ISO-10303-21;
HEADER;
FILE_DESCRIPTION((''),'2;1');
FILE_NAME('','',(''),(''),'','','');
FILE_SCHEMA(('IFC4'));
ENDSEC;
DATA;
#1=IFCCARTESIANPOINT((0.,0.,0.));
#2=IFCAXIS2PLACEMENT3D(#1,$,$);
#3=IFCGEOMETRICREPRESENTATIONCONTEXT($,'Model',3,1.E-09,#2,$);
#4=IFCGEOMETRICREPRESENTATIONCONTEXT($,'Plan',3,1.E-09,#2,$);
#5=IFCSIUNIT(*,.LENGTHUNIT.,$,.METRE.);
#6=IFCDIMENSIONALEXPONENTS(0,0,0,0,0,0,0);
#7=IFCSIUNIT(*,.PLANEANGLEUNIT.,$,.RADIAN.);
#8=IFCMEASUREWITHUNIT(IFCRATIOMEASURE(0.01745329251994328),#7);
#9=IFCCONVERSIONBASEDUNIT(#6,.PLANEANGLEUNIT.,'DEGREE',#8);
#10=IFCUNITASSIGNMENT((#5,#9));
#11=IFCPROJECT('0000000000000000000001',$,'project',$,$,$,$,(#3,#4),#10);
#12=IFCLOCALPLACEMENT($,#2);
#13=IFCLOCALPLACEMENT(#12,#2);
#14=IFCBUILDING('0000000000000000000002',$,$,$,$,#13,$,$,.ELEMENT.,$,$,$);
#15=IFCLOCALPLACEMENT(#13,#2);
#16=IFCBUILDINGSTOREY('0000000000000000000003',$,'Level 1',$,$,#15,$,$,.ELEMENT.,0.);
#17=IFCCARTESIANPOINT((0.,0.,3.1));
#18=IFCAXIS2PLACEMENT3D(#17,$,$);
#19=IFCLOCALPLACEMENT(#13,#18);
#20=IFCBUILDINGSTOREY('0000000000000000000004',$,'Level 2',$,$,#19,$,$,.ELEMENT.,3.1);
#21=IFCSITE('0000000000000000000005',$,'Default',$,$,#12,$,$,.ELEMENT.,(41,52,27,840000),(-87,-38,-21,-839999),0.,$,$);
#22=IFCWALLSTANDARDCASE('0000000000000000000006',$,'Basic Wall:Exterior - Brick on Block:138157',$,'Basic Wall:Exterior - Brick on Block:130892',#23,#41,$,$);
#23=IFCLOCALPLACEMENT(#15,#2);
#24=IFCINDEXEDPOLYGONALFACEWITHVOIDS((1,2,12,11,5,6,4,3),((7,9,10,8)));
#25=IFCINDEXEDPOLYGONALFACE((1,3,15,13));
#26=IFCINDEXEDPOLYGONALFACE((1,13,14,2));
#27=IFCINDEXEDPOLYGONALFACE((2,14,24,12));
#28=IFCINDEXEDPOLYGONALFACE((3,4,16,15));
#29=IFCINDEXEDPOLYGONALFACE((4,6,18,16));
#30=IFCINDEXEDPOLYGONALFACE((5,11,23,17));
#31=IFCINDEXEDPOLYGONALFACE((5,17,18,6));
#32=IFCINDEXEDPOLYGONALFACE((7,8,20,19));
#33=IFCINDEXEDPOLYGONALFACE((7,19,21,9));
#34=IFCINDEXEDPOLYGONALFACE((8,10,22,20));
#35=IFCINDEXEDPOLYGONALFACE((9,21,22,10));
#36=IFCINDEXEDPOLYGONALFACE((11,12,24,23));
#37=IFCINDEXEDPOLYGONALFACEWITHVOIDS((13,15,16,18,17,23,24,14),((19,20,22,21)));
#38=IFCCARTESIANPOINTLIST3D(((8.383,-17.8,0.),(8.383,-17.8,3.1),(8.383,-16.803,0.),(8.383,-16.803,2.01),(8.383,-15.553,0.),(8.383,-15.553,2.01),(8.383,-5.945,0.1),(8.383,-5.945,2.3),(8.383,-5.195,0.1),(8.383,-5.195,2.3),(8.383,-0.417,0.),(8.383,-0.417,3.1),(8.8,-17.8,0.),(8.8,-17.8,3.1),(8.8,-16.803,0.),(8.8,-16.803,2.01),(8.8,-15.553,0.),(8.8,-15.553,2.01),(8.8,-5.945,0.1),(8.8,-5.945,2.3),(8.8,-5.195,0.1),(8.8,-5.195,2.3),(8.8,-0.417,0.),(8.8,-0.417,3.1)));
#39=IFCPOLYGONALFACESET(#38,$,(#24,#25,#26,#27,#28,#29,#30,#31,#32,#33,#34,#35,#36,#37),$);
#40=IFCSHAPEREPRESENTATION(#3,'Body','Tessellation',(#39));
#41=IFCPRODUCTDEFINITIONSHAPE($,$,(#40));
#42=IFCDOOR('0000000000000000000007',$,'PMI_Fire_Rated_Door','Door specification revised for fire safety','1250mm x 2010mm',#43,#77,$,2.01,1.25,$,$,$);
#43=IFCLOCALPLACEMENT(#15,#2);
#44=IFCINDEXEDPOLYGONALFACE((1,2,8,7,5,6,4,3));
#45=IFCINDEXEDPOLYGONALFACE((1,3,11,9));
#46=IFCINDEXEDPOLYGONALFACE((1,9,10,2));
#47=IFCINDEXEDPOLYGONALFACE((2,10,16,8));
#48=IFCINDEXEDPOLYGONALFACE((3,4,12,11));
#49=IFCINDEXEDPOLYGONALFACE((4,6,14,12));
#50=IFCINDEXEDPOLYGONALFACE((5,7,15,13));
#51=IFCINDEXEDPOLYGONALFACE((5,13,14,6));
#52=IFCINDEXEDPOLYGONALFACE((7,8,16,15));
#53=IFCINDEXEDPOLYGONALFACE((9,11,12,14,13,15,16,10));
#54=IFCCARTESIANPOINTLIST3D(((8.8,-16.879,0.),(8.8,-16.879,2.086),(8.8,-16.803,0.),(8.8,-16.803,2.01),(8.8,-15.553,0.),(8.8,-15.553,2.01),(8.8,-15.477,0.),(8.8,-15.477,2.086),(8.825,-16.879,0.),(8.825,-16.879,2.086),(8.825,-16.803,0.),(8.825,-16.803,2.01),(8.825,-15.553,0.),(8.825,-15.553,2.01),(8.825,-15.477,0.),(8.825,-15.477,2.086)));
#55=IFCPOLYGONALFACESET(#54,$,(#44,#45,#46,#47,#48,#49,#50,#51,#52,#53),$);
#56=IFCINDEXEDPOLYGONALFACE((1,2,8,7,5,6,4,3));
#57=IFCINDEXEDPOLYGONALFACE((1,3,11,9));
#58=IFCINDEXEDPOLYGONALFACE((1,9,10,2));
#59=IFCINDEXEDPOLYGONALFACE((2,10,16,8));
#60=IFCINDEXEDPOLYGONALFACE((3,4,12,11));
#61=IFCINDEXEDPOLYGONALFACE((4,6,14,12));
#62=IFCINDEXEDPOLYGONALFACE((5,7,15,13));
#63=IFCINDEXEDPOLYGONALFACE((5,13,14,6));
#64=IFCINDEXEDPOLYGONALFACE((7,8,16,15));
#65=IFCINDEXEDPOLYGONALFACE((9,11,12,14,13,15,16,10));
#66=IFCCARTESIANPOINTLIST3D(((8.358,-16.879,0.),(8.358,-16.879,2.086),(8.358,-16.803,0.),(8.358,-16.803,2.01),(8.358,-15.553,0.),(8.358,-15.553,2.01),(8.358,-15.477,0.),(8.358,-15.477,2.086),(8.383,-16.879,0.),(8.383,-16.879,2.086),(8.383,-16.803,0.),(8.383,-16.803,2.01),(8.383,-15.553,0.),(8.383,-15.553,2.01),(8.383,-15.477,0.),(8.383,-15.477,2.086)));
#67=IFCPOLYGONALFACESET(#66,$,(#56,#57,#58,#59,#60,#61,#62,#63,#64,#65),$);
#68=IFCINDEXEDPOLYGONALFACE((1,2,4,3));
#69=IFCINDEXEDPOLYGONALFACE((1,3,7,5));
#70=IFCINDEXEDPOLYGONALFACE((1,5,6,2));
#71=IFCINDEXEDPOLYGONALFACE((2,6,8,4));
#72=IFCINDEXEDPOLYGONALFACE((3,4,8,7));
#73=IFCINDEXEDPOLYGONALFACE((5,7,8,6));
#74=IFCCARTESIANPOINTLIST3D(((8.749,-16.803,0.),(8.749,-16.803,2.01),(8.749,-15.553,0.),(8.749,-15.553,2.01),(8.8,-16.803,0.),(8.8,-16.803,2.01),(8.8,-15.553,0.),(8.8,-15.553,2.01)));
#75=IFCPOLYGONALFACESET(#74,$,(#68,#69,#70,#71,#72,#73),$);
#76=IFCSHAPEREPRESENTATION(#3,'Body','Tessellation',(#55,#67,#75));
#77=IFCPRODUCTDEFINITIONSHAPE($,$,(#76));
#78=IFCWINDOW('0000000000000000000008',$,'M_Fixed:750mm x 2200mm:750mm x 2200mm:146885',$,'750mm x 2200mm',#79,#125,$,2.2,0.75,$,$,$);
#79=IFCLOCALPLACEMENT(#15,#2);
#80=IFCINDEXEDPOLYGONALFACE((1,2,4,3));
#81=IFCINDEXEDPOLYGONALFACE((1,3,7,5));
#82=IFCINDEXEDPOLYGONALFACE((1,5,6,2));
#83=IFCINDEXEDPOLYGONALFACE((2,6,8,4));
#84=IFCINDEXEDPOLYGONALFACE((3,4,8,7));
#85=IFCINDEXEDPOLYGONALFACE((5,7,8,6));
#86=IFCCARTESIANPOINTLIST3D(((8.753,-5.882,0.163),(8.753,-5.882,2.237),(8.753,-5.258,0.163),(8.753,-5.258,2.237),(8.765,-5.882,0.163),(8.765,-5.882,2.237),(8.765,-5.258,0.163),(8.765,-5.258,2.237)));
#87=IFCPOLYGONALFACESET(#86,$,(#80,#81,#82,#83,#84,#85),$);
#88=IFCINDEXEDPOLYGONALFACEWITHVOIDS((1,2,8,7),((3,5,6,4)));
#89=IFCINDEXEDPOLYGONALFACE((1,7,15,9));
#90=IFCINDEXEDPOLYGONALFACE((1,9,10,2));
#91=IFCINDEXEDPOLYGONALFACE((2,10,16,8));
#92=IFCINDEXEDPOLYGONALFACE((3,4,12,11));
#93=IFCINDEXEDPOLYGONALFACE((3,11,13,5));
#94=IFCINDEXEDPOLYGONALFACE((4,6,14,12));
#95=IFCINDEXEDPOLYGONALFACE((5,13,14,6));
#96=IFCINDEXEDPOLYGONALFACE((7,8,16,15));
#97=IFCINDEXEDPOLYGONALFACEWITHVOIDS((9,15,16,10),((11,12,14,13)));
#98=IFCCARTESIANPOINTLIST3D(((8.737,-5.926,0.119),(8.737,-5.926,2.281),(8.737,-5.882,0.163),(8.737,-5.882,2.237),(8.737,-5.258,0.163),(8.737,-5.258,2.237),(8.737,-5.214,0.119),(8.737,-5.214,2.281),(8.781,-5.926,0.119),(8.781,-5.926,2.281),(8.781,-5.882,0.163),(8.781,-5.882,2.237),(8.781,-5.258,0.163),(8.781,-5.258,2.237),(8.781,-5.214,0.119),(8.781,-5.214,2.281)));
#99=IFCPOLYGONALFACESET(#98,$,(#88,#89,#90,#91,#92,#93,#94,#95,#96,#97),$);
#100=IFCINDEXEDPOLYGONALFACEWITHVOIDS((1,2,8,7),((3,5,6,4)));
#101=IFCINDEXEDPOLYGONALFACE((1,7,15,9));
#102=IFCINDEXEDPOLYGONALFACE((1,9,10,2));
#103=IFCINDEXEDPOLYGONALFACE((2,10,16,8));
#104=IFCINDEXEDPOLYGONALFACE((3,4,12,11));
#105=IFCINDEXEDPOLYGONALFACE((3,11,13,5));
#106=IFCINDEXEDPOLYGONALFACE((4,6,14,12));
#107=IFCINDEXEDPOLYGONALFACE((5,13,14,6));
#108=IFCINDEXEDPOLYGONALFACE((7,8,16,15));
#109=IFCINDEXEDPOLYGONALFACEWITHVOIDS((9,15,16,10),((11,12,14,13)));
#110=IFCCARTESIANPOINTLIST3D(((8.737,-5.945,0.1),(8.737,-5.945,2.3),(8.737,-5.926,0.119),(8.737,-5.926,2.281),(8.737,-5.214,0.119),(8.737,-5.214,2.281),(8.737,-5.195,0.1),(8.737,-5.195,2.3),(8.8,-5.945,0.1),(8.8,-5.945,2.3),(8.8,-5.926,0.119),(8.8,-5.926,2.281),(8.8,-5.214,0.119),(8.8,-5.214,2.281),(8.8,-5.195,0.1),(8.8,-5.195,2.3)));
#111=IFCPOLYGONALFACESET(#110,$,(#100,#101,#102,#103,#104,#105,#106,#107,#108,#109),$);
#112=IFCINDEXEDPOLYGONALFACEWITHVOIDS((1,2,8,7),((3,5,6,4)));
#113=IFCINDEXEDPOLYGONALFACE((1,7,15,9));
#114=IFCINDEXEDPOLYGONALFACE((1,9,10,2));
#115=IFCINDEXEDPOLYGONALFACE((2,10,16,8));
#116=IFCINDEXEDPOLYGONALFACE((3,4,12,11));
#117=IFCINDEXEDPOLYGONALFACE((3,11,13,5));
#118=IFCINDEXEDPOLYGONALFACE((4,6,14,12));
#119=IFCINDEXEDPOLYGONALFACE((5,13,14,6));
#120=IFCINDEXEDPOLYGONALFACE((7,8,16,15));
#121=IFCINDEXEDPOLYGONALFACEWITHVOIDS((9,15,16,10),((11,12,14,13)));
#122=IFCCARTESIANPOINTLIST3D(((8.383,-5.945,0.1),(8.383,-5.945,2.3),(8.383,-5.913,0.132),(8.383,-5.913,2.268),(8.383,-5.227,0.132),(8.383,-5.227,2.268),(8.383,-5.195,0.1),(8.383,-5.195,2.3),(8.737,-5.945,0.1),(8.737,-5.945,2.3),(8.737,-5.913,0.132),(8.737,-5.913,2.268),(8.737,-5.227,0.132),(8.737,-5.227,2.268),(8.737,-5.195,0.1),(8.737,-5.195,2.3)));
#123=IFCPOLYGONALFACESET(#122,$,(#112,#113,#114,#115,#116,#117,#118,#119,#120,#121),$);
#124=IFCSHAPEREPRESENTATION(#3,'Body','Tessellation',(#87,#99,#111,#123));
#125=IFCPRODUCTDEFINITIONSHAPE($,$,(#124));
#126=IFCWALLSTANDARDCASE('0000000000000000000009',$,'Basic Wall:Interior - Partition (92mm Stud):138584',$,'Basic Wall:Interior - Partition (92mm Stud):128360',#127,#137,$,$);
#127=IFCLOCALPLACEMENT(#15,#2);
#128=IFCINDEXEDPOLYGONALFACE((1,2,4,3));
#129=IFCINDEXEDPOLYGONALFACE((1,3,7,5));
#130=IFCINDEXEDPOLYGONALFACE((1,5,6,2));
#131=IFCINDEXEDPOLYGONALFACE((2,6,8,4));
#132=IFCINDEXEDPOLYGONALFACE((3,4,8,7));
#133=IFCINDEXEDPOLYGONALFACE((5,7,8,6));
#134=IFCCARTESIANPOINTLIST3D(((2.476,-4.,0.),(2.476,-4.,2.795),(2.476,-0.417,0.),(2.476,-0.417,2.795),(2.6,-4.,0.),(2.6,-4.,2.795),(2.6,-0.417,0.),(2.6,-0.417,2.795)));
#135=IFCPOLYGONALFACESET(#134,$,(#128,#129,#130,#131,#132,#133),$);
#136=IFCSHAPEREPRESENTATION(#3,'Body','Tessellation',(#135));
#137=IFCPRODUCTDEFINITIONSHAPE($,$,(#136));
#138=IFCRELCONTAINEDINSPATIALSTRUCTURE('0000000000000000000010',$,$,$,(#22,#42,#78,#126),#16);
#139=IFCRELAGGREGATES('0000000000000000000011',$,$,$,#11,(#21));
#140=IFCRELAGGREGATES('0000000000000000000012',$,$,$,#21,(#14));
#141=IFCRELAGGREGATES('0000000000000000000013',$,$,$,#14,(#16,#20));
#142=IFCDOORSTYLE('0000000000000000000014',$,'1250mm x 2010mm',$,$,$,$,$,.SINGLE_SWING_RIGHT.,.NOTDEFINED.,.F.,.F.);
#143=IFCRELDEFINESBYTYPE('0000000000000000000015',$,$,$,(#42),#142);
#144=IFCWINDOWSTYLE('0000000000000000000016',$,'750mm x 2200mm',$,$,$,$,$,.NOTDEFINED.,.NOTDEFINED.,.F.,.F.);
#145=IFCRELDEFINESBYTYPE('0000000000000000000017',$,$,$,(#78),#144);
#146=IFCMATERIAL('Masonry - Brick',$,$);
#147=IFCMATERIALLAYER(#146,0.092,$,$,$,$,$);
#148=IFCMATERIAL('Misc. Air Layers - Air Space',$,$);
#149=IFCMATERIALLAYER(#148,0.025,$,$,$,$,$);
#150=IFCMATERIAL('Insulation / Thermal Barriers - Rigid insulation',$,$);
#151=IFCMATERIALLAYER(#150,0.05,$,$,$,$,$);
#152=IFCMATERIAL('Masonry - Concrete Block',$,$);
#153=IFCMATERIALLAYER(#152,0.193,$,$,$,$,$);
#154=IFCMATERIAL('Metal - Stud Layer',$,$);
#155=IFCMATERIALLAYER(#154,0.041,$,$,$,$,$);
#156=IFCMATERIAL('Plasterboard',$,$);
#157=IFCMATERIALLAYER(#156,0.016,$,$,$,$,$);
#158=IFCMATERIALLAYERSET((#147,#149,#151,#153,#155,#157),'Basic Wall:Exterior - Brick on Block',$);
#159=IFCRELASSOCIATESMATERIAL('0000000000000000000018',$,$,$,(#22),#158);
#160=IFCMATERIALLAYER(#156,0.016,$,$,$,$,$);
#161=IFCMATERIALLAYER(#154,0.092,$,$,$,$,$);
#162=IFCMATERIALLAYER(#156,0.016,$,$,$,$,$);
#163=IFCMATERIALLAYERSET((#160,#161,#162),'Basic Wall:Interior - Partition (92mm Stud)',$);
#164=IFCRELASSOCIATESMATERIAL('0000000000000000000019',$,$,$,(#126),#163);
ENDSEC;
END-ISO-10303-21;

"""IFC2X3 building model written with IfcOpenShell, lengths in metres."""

from ifc_helpers import new_model, entity, si_unit, converted_unit, frame, frame_2d, origin, origin_2d_with_axis, place, context, project, spatial, polyline, rectangle, outline, extrude, source, transform, mapped, material, layer, layer_set, layer_usage, type_object, type_shapes, element, fill, save


model = new_model("IFC2X3")

# Units and contexts
model_context = context("Model", 3, precision=1e-09, world=origin())
plan_context = context("Plan", 3, precision=1e-09, world=origin())
ifc_project = project(units=[si_unit("LENGTHUNIT", "METRE"), converted_unit("PLANEANGLEUNIT", "DEGREE", entity("IfcRatioMeasure", 0.01745329251994328), si_unit("PLANEANGLEUNIT", "RADIAN"), dimensions=[0, 0, 0, 0, 0, 0, 0])], contexts=[model_context, plan_context])

# Site, building, storey
site_placement = place(None, origin())
site = spatial("IfcSite", under=ifc_project, at=site_placement, Name="Default", CompositionType="ELEMENT", RefLatitude=(41, 52, 27, 840000), RefLongitude=(-87, -38, -21, -839999), RefElevation=0.0)
building_placement = place(site_placement, origin())
building = spatial("IfcBuilding", under=site, at=building_placement, CompositionType="ELEMENT")
storey_1_placement = place(building_placement, origin())
storey_1 = spatial("IfcBuildingStorey", under=building, at=storey_1_placement, Name="Level 1", CompositionType="ELEMENT", Elevation=0.0)

# Shared definitions
ifc_material_1 = material(Name="Masonry - Brick")
ifc_layer_1 = layer(ifc_material_1, 0.092)
ifc_material_2 = material(Name="Misc. Air Layers - Air Space")
ifc_layer_2 = layer(ifc_material_2, 0.025)
ifc_material_3 = material(Name="Insulation / Thermal Barriers - Rigid insulation")
ifc_layer_3 = layer(ifc_material_3, 0.05)
ifc_material_4 = material(Name="Masonry - Concrete Block")
ifc_layer_4 = layer(ifc_material_4, 0.193)
ifc_material_5 = material(Name="Metal - Stud Layer")
ifc_layer_5 = layer(ifc_material_5, 0.041)
ifc_material_6 = material(Name="Plasterboard")
ifc_layer_6 = layer(ifc_material_6, 0.016)
ifc_layer_set_1 = layer_set([ifc_layer_1, ifc_layer_2, ifc_layer_3, ifc_layer_4, ifc_layer_5, ifc_layer_6], Name="Basic Wall:Exterior - Brick on Block")

# Wall, openings, door, window
ifc_layer_usage_1 = layer_usage(ifc_layer_set_1, "AXIS2", "NEGATIVE", 0.2085)
wall_1_placement = place(storey_1_placement, frame((8.5915, -0.417, 0.0), z_axis=(0.0, 0.0, 1.0), x_axis=(0.0, -1.0, 0.0)))
wall_1 = element("IfcWallStandardCase", 1, at=wall_1_placement, inside=storey_1, material=ifc_layer_usage_1, Name="Basic Wall:Exterior - Brick on Block:138157", ObjectType="Basic Wall:Exterior - Brick on Block:130892", context=model_context, shape_type="SweptSolid", body=[
    extrude(rectangle(XDim=17.383, YDim=0.417, at=frame_2d((8.6915, 0.0), x_axis=(-1.0, 0.0))), origin(), (0.0, 0.0, 1.0), 3.1),
])
opening_1_placement = place(wall_1_placement, frame((15.136, -0.2085, 0.0)))
opening_1 = element("IfcOpeningElement", 2, at=opening_1_placement, cuts=wall_1, ObjectType="Opening", context=model_context, shape_type="SweptSolid", body=[
    extrude(rectangle(XDim=1.25, YDim=2.01, at=frame_2d((1.005, 0.625), x_axis=(0.0, 1.0))), frame((0.0, 0.0, 0.0), z_axis=(0.0, 1.0, 0.0), x_axis=(0.0, 0.0, 1.0)), (0.0, 0.0, 1.0), 0.417),
])
opening_2_placement = place(wall_1_placement, frame((4.778, -0.2085, 0.1)))
opening_2 = element("IfcOpeningElement", 3, at=opening_2_placement, cuts=wall_1, ObjectType="Opening", context=model_context, shape_type="SweptSolid", body=[
    extrude(rectangle(XDim=2.2, YDim=0.75, at=frame_2d((1.1, 0.375), x_axis=(1.0, 0.0))), frame((0.0, 0.0, 0.0), z_axis=(0.0, 1.0, 0.0), x_axis=(0.0, 0.0, 1.0)), (0.0, 0.0, 1.0), 0.417),
])
door_style_1 = type_object("IfcDoorStyle", Name="1250mm x 2010mm", ConstructionType="NOTDEFINED", OperationType="SINGLE_SWING_RIGHT", ParameterTakesPrecedence=False, Sizeable=False)
shared_shape_1 = source(origin(), model_context, "Body", "SweptSolid", [
    extrude(outline(polyline([(-0.701, -1.062), (0.701, -1.062), (0.701, 1.024), (0.625, 1.024), (0.625, -0.986), (-0.625, -0.986), (-0.625, 1.024), (-0.701, 1.024), (-0.701, -1.062)])), frame((0.625, 0.417, 1.024), z_axis=(0.0, 1.0, 0.0), x_axis=(1.0, 0.0, 0.0)), (0.0, 0.0, 1.0), 0.025),
    extrude(outline(polyline([(-1.062, -0.701), (1.024, -0.701), (1.024, -0.625), (-0.986, -0.625), (-0.986, 0.625), (1.024, 0.625), (1.024, 0.701), (-1.062, 0.701), (-1.062, -0.701)])), frame((0.625, -0.025, 1.024), z_axis=(0.0, 1.0, 0.0), x_axis=(0.0, 0.0, -1.0)), (0.0, 0.0, 1.0), 0.025),
    extrude(rectangle(XDim=0.051, YDim=1.25, at=origin_2d_with_axis()), frame((0.625, 0.3915, 0.0), z_axis=(0.0, 0.0, 1.0), x_axis=(0.0, 1.0, 0.0)), (0.0, 0.0, 1.0), 2.01),
])
type_shapes(door_style_1, [shared_shape_1])
door_1_placement = place(opening_1_placement, origin())
door_1 = element("IfcDoor", 4, at=door_1_placement, inside=storey_1, type_object=door_style_1, Name="PMI_Fire_Rated_Door", Description="Door specification revised for fire safety", ObjectType="1250mm x 2010mm", OverallHeight=2.01, OverallWidth=1.25, context=model_context, shape_type="MappedRepresentation", body=[
    mapped(shared_shape_1, transform((0.0, 0.0, 0.0), scale=1.0)),
])
fill(opening_1, door_1)
window_style_1 = type_object("IfcWindowStyle", Name="750mm x 2200mm", ConstructionType="NOTDEFINED", OperationType="NOTDEFINED", ParameterTakesPrecedence=False, Sizeable=False)
shared_shape_2 = source(origin(), model_context, "Body", "SweptSolid", [
    extrude(rectangle(XDim=0.012, YDim=0.624, at=origin_2d_with_axis()), frame((0.375, 0.376, 0.063), z_axis=(0.0, 0.0, 1.0), x_axis=(0.0, -1.0, 0.0)), (0.0, 0.0, 1.0), 2.074),
    extrude(outline(polyline([(-0.356, -1.081), (0.356, -1.081), (0.356, 1.081), (-0.356, 1.081), (-0.356, -1.081)]), holes=[polyline([(-0.312, -1.037), (-0.312, 1.037), (0.312, 1.037), (0.312, -1.037), (-0.312, -1.037)])]), frame((0.375, 0.354, 1.1), z_axis=(0.0, 1.0, 0.0), x_axis=(1.0, 0.0, 0.0)), (0.0, 0.0, 1.0), 0.044),
    extrude(outline(polyline([(-0.375, -1.1), (0.375, -1.1), (0.375, 1.1), (-0.375, 1.1), (-0.375, -1.1)]), holes=[polyline([(-0.356, -1.081), (-0.356, 1.081), (0.356, 1.081), (0.356, -1.081), (-0.356, -1.081)])]), frame((0.375, 0.354, 1.1), z_axis=(0.0, 1.0, 0.0), x_axis=(1.0, 0.0, 0.0)), (0.0, 0.0, 1.0), 0.063),
    extrude(outline(polyline([(-0.375, -1.1), (0.375, -1.1), (0.375, 1.1), (-0.375, 1.1), (-0.375, -1.1)]), holes=[polyline([(-0.343, -1.068), (-0.343, 1.068), (0.343, 1.068), (0.343, -1.068), (-0.343, -1.068)])]), frame((0.375, 0.0, 1.1), z_axis=(0.0, 1.0, 0.0), x_axis=(1.0, 0.0, 0.0)), (0.0, 0.0, 1.0), 0.354),
])
type_shapes(window_style_1, [shared_shape_2])
window_1_placement = place(opening_2_placement, origin())
window_1 = element("IfcWindow", 5, at=window_1_placement, inside=storey_1, type_object=window_style_1, Name="M_Fixed:750mm x 2200mm:750mm x 2200mm:146885", ObjectType="750mm x 2200mm", OverallHeight=2.2, OverallWidth=0.75, context=model_context, shape_type="MappedRepresentation", body=[
    mapped(shared_shape_2, transform((0.0, 0.0, 0.0), scale=1.0)),
])
fill(opening_2, window_1)

# Wall
ifc_layer_7 = layer(ifc_material_6, 0.016)
ifc_layer_8 = layer(ifc_material_5, 0.092)
ifc_layer_9 = layer(ifc_material_6, 0.016)
ifc_layer_set_2 = layer_set([ifc_layer_7, ifc_layer_8, ifc_layer_9], Name="Basic Wall:Interior - Partition (92mm Stud)")
ifc_layer_usage_2 = layer_usage(ifc_layer_set_2, "AXIS2", "NEGATIVE", 0.062)
wall_2_placement = place(storey_1_placement, frame((2.538, -0.417, 0.0), z_axis=(0.0, 0.0, 1.0), x_axis=(0.0, -1.0, 0.0)))
element("IfcWallStandardCase", 6, at=wall_2_placement, inside=storey_1, material=ifc_layer_usage_2, Name="Basic Wall:Interior - Partition (92mm Stud):138584", ObjectType="Basic Wall:Interior - Partition (92mm Stud):128360", context=model_context, shape_type="SweptSolid", body=[
    extrude(rectangle(XDim=3.583, YDim=0.124, at=frame_2d((1.7915, 0.0), x_axis=(-1.0, 0.0))), origin(), (0.0, 0.0, 1.0), 2.795),
])

# Shared definitions
storey_2_placement = place(building_placement, frame((0.0, 0.0, 3.1)))
storey_2 = spatial("IfcBuildingStorey", under=building, at=storey_2_placement, Name="Level 2", CompositionType="ELEMENT", Elevation=3.1)

save(model, "model.ifc")
